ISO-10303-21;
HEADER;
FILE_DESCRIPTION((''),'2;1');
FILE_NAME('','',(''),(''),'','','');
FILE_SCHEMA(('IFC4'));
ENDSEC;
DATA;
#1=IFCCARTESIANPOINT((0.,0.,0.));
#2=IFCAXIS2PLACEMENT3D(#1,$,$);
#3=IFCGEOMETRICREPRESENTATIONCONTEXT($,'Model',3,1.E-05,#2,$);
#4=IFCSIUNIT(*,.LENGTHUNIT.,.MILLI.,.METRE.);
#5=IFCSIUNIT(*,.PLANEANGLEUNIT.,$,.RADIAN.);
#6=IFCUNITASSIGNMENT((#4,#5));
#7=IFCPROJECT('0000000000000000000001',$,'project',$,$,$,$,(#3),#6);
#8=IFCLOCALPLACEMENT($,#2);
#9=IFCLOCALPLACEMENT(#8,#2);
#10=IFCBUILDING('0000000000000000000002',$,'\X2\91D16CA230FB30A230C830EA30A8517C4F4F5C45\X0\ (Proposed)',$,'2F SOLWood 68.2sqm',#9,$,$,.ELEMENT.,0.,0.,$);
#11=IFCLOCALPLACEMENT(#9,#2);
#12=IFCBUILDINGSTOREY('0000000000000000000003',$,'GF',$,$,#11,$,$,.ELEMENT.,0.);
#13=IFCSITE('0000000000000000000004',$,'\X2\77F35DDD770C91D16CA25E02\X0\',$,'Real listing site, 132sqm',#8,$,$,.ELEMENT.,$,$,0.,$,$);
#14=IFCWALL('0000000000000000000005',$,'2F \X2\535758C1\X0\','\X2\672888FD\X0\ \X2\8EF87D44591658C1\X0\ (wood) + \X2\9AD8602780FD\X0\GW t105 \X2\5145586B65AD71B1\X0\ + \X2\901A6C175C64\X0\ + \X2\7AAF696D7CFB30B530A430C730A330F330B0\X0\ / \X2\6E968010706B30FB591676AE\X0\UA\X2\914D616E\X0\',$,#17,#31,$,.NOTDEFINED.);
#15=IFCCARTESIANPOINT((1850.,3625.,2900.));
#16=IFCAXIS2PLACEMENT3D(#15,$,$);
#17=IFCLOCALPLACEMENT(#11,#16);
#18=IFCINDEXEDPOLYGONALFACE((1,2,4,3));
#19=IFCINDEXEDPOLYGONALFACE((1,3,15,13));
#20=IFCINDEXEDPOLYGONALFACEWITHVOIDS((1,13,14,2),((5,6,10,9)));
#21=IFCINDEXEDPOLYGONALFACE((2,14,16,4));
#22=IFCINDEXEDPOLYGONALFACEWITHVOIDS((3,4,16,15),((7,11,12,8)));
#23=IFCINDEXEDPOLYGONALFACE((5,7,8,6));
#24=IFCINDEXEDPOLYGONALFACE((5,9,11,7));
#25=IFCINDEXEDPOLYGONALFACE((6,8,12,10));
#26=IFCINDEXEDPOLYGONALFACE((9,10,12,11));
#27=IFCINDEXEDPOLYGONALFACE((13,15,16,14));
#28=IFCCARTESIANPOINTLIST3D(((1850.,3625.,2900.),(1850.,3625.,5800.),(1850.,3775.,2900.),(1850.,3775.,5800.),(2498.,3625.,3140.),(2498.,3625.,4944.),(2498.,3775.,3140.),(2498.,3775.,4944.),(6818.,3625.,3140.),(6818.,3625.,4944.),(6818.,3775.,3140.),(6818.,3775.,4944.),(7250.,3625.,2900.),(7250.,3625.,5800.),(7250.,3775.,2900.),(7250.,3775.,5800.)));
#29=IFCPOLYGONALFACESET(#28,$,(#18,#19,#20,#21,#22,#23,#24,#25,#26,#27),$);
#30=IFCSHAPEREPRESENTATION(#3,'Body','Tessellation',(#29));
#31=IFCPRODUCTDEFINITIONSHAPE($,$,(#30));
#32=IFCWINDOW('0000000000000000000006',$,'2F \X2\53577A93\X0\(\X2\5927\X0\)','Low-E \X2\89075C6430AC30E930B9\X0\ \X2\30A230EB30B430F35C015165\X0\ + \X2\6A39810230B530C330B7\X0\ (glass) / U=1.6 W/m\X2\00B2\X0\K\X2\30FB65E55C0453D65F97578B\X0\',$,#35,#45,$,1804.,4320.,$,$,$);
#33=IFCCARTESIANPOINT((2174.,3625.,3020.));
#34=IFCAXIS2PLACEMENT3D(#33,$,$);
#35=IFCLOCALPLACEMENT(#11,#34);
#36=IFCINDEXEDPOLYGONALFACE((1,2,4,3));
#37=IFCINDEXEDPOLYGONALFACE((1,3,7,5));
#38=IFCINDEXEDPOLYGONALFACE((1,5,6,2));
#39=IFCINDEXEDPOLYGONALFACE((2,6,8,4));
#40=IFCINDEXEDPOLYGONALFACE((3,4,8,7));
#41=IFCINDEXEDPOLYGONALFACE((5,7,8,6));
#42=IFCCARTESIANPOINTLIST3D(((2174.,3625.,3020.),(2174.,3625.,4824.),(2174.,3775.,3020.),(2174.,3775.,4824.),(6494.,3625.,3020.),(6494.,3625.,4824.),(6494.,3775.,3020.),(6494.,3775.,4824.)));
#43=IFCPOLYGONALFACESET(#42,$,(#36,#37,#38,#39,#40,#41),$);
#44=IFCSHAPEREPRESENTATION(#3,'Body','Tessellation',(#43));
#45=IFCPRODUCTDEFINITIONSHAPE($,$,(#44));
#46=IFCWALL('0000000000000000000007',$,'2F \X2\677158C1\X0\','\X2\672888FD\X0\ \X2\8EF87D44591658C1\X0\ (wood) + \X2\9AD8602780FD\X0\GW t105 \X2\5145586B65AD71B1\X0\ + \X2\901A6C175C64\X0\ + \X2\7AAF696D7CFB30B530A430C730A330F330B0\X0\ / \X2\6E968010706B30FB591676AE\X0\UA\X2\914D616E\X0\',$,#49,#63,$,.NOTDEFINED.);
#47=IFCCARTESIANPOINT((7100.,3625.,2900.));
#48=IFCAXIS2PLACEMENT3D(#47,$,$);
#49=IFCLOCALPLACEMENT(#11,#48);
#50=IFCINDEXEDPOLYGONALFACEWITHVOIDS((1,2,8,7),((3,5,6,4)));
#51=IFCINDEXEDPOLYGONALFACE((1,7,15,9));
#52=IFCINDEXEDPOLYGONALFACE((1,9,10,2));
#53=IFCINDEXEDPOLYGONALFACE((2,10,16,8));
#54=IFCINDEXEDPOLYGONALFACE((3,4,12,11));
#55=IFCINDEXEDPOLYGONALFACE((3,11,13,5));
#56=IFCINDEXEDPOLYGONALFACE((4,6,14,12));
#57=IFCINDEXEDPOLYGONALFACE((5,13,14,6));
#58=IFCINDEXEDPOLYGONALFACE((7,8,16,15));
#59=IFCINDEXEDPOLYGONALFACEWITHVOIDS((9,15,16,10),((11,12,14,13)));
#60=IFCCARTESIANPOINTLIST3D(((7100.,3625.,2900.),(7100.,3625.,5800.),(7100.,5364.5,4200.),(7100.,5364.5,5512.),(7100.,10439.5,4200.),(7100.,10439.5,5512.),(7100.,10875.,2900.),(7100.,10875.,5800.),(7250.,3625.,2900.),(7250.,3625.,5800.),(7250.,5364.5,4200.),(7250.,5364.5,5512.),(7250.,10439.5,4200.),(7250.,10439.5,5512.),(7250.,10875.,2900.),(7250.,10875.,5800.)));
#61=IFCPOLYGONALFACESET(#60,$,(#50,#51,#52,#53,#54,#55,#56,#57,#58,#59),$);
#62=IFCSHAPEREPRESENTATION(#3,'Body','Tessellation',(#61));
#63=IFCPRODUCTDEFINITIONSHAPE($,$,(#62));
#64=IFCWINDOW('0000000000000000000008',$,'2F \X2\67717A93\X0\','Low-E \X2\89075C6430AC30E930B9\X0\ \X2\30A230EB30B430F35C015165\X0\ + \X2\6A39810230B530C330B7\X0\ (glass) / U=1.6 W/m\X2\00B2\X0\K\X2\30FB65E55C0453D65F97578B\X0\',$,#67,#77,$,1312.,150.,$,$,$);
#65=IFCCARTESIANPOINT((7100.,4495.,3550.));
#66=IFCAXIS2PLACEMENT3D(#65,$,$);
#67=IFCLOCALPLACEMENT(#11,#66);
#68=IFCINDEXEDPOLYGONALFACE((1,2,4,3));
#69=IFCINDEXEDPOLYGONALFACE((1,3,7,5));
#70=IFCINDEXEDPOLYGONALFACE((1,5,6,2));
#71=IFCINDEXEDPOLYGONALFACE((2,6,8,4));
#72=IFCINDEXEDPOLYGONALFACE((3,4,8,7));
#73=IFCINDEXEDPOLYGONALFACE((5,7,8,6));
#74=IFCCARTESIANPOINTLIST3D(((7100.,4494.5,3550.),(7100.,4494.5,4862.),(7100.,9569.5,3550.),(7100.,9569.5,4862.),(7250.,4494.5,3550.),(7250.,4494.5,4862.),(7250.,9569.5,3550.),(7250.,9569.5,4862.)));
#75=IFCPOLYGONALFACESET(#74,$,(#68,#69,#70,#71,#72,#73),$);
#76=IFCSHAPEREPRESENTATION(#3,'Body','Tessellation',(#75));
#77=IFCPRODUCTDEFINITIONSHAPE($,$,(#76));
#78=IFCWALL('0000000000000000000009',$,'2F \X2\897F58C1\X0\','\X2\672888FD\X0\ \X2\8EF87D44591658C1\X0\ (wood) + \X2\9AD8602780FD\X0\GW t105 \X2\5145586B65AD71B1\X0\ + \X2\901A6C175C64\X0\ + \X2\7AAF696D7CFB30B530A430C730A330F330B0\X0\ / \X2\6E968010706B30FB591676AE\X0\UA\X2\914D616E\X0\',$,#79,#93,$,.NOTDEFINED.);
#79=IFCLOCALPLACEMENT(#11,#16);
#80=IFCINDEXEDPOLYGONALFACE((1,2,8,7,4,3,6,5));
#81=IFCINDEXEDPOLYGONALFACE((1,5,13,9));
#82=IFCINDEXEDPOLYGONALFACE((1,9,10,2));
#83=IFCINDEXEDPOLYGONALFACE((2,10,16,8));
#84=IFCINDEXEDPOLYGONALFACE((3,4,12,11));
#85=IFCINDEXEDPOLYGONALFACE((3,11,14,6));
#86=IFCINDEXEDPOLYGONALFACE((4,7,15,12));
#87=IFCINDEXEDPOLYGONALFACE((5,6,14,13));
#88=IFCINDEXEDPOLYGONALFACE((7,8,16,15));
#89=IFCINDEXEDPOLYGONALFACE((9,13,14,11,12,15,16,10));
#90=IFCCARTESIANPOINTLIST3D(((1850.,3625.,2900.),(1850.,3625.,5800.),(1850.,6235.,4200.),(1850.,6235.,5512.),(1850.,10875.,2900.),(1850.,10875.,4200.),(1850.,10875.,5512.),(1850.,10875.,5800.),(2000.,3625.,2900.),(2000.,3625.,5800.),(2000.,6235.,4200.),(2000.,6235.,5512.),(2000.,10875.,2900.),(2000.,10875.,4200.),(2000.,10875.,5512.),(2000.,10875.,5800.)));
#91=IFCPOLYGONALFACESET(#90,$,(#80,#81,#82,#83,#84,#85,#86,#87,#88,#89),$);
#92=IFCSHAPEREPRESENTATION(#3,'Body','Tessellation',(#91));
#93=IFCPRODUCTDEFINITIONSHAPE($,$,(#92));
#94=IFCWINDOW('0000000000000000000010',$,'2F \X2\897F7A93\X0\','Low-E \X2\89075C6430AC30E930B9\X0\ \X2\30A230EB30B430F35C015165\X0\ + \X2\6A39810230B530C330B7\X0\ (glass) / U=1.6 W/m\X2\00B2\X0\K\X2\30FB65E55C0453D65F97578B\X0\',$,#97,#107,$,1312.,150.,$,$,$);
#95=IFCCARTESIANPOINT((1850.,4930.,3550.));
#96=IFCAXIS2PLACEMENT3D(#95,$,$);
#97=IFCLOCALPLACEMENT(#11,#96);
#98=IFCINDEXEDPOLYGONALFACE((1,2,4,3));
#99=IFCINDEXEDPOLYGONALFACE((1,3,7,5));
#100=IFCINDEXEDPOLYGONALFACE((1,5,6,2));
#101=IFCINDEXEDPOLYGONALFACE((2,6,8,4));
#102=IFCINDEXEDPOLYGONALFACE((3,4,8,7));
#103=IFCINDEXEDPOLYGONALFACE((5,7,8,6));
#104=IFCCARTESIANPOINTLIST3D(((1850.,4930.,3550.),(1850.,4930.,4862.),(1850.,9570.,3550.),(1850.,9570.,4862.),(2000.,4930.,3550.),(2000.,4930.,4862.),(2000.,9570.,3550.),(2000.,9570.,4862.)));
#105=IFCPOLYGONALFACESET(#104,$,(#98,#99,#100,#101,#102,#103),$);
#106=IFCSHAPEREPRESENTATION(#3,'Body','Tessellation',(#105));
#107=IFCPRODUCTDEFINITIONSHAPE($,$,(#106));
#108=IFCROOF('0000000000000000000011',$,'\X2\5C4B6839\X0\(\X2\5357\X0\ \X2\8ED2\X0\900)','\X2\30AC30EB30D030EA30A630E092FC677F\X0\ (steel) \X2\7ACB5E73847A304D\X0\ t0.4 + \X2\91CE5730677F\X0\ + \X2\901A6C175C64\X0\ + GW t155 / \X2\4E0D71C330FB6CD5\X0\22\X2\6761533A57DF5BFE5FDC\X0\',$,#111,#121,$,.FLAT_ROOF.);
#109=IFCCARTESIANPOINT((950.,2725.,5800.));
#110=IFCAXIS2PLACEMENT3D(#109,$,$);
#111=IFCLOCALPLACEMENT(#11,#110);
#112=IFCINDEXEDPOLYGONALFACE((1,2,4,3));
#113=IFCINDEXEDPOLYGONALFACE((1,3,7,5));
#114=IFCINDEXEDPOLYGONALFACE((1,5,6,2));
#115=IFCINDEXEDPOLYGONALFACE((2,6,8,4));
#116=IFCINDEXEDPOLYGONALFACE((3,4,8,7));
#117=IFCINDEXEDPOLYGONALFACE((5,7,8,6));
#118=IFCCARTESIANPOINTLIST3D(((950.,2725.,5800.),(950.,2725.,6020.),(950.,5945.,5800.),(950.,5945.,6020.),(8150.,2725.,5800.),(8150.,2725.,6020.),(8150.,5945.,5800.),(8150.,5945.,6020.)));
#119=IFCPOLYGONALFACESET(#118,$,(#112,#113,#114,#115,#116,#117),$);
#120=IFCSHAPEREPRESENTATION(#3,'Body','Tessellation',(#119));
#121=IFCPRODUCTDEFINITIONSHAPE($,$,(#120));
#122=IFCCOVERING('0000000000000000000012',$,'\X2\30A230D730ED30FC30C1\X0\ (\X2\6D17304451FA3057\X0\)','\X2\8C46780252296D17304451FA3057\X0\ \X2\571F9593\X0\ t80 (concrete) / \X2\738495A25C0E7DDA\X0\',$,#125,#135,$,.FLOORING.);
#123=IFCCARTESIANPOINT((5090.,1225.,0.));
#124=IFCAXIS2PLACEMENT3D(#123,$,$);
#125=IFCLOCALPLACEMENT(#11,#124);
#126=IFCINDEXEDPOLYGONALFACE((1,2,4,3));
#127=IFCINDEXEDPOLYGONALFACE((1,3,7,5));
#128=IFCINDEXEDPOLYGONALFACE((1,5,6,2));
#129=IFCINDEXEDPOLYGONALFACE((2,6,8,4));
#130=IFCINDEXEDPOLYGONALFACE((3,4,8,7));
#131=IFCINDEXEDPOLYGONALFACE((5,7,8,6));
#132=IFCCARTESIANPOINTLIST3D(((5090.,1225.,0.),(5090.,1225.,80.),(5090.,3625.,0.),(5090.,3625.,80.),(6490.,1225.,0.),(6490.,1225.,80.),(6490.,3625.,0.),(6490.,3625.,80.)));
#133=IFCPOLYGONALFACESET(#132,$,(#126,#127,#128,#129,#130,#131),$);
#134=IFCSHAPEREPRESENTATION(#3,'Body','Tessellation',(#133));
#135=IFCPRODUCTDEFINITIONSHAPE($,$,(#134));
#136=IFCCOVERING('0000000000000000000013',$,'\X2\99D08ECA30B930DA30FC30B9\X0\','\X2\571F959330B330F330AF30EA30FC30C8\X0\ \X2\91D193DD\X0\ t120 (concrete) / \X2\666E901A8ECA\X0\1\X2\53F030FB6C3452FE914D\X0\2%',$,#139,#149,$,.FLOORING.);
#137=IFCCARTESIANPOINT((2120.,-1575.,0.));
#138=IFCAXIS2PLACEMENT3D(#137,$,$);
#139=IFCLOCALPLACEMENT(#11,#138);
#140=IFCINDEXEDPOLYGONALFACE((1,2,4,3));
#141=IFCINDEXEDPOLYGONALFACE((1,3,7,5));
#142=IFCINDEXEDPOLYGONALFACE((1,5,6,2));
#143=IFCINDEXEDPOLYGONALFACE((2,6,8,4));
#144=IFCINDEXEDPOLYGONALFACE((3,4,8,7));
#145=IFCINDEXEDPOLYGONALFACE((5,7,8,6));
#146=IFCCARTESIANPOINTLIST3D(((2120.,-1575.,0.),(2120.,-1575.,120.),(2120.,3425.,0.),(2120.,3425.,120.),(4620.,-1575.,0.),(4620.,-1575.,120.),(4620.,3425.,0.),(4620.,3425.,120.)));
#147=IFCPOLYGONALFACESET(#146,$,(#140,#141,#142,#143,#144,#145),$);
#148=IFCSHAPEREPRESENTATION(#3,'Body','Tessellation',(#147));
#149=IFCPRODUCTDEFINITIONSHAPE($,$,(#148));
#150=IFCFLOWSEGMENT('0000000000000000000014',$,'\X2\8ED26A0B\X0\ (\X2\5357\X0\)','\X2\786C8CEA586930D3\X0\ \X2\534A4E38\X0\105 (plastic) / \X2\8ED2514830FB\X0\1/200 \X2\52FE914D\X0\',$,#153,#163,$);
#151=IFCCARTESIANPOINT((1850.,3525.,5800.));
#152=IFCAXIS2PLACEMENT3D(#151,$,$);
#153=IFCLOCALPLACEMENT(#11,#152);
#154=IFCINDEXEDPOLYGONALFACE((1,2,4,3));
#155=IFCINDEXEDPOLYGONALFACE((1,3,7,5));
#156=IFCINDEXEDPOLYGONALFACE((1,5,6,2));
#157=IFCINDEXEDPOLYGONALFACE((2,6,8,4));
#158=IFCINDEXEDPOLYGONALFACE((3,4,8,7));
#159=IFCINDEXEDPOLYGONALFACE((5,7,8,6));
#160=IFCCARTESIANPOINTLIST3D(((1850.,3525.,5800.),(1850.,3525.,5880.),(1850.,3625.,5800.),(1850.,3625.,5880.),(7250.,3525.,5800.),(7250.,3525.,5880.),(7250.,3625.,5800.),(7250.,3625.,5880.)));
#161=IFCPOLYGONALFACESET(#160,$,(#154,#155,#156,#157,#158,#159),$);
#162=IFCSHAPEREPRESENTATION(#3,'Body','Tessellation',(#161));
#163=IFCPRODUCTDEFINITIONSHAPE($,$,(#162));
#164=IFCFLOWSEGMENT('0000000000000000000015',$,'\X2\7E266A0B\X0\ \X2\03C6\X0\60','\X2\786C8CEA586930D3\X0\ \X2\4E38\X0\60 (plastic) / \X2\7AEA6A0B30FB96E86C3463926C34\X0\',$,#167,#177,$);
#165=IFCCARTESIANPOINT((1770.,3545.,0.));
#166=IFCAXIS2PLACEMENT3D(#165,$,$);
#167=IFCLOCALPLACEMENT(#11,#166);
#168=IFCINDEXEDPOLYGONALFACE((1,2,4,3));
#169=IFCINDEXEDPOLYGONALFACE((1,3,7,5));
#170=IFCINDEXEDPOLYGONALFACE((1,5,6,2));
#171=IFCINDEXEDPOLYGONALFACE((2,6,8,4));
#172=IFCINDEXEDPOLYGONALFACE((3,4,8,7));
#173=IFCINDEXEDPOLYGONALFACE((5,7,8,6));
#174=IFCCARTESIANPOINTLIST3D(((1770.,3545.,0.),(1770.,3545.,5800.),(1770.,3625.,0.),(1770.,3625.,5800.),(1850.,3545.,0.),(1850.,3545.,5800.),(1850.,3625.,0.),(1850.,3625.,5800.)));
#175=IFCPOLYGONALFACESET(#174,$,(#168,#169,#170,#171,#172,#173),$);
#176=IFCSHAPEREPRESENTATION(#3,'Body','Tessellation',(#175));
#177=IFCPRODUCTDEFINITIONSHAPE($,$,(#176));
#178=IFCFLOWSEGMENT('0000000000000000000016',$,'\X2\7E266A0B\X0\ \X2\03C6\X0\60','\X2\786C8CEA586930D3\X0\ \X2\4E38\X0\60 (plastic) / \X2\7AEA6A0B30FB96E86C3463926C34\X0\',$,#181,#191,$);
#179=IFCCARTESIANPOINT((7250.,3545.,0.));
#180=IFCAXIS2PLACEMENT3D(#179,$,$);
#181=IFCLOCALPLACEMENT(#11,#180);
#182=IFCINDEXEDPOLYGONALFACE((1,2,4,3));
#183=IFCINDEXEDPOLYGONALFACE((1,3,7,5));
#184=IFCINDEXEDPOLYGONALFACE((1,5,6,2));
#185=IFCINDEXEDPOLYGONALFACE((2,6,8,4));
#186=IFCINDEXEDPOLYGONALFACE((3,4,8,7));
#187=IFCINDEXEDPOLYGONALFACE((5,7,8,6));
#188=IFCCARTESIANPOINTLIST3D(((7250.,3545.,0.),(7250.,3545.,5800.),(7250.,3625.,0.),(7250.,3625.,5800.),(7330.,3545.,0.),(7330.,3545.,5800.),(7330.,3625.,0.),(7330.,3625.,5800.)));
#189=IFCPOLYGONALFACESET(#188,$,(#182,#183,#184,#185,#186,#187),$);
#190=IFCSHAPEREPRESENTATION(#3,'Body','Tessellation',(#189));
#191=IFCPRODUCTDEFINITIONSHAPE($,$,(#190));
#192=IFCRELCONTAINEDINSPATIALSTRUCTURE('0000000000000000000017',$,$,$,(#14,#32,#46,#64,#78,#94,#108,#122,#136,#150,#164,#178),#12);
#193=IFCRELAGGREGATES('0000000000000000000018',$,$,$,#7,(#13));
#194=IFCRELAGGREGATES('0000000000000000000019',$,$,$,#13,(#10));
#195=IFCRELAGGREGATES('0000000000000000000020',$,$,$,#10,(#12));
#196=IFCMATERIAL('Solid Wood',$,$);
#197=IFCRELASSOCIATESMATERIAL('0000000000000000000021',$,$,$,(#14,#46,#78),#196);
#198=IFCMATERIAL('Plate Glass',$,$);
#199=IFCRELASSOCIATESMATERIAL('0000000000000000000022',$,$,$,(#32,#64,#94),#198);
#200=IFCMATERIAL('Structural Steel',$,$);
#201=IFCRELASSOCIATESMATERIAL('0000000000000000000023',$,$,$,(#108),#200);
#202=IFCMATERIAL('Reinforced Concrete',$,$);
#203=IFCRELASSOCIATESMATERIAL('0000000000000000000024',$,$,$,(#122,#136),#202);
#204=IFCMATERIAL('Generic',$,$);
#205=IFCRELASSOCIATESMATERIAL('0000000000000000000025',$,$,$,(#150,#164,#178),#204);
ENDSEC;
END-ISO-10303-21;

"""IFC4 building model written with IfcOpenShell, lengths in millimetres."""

from ifc_helpers import new_model, si_unit, frame, frame_2d, origin, place, context, project, spatial, rectangle, extrude, material, element, fill, save


model = new_model("IFC4")

# Units and contexts
model_context = context("Model", 3, precision=1e-05, world=origin())
ifc_project = project(units=[si_unit("LENGTHUNIT", "METRE", prefix="MILLI"), si_unit("PLANEANGLEUNIT", "RADIAN")], contexts=[model_context])

# Site, building, storey
site_placement = place(None, origin())
site = spatial("IfcSite", under=ifc_project, at=site_placement, Name="石川県金沢市", ObjectType="Real listing site, 132sqm", CompositionType="ELEMENT", RefElevation=0.0)
building_placement = place(site_placement, origin())
building = spatial("IfcBuilding", under=site, at=building_placement, Name="金沢・アトリエ兼住居 (Proposed)", ObjectType="2F SOLWood 68.2sqm", CompositionType="ELEMENT", ElevationOfRefHeight=0.0, ElevationOfTerrain=0.0)
storey_placement = place(building_placement, origin())
storey = spatial("IfcBuildingStorey", under=building, at=storey_placement, Name="GF", CompositionType="ELEMENT", Elevation=0.0)

# Shared definitions
ifc_material_1 = material(Name="Solid Wood")

# Shared definitions
ifc_material_2 = material(Name="Reinforced Concrete")

# Shared definitions
ifc_material_3 = material(Name="Plate Glass")

# Walls, openings, windows
wall_1_placement = place(storey_placement, frame((1850.0, 3625.0, 2900.0)))
wall_1 = element("IfcWall", 1, at=wall_1_placement, inside=storey, material=ifc_material_1, Name="2F 南壁", Description="木製 軸組外壁 (wood) + 高性能GW t105 充填断熱 + 通気層 + 窯業系サイディング / 準耐火・外皮UA配慮", PredefinedType="NOTDEFINED", context=model_context, shape_type="SweptSolid", body=[
    extrude(rectangle(XDim=5400.0, YDim=150.0, at=frame_2d((2700.0, 75.0))), frame((1850.0, 3625.0, 2900.0)), (0.0, 0.0, 1.0), 2900.0),
])
opening_1_placement = place(storey_placement, frame((2174.0, 3625.0, 3020.0)))
opening_1 = element("IfcOpeningElement", 2, at=opening_1_placement, cuts=wall_1, PredefinedType="NOTDEFINED", context=model_context, shape_type="SweptSolid", body=[
    extrude(rectangle(XDim=4320.0, YDim=150.0, at=frame_2d((2160.0, 75.0))), frame((2174.0, 3625.0, 3020.0)), (0.0, 0.0, 1.0), 1804.0),
])
window_1_placement = place(storey_placement, frame((2174.0, 3625.0, 3020.0)))
window_1 = element("IfcWindow", 3, at=window_1_placement, inside=storey, material=ifc_material_3, Name="2F 南窓(大)", Description="Low-E 複層ガラス アルゴン封入 + 樹脂サッシ (glass) / U=1.6 W/m²K・日射取得型", OverallHeight=1804.0, OverallWidth=4320.0, context=model_context, shape_type="SweptSolid", body=[
    extrude(rectangle(XDim=4320.0, YDim=150.0, at=frame_2d((2160.0, 75.0))), frame((2174.0, 3625.0, 3020.0)), (0.0, 0.0, 1.0), 1804.0),
])
fill(opening_1, window_1)
wall_2_placement = place(storey_placement, frame((7100.0, 3625.0, 2900.0)))
wall_2 = element("IfcWall", 4, at=wall_2_placement, inside=storey, material=ifc_material_1, Name="2F 東壁", Description="木製 軸組外壁 (wood) + 高性能GW t105 充填断熱 + 通気層 + 窯業系サイディング / 準耐火・外皮UA配慮", PredefinedType="NOTDEFINED", context=model_context, shape_type="SweptSolid", body=[
    extrude(rectangle(XDim=150.0, YDim=7250.0, at=frame_2d((75.0, 3625.0))), frame((7100.0, 3625.0, 2900.0)), (0.0, 0.0, 1.0), 2900.0),
])
opening_2_placement = place(storey_placement, frame((7100.0, 4495.0, 3550.0)))
opening_2 = element("IfcOpeningElement", 5, at=opening_2_placement, cuts=wall_2, PredefinedType="NOTDEFINED", context=model_context, shape_type="SweptSolid", body=[
    extrude(rectangle(XDim=150.0, YDim=5075.0, at=frame_2d((75.0, 2537.0))), frame((7100.0, 4495.0, 3550.0)), (0.0, 0.0, 1.0), 1312.0),
])
window_2_placement = place(storey_placement, frame((7100.0, 4495.0, 3550.0)))
window_2 = element("IfcWindow", 6, at=window_2_placement, inside=storey, material=ifc_material_3, Name="2F 東窓", Description="Low-E 複層ガラス アルゴン封入 + 樹脂サッシ (glass) / U=1.6 W/m²K・日射取得型", OverallHeight=1312.0, OverallWidth=150.0, context=model_context, shape_type="SweptSolid", body=[
    extrude(rectangle(XDim=150.0, YDim=5075.0, at=frame_2d((75.0, 2537.0))), frame((7100.0, 4495.0, 3550.0)), (0.0, 0.0, 1.0), 1312.0),
])
fill(opening_2, window_2)
wall_3_placement = place(storey_placement, frame((1850.0, 3625.0, 2900.0)))
wall_3 = element("IfcWall", 7, at=wall_3_placement, inside=storey, material=ifc_material_1, Name="2F 西壁", Description="木製 軸組外壁 (wood) + 高性能GW t105 充填断熱 + 通気層 + 窯業系サイディング / 準耐火・外皮UA配慮", PredefinedType="NOTDEFINED", context=model_context, shape_type="SweptSolid", body=[
    extrude(rectangle(XDim=150.0, YDim=7250.0, at=frame_2d((75.0, 3625.0))), frame((1850.0, 3625.0, 2900.0)), (0.0, 0.0, 1.0), 2900.0),
])
opening_3_placement = place(storey_placement, frame((1850.0, 4930.0, 3550.0)))
opening_3 = element("IfcOpeningElement", 8, at=opening_3_placement, cuts=wall_3, PredefinedType="NOTDEFINED", context=model_context, shape_type="SweptSolid", body=[
    extrude(rectangle(XDim=150.0, YDim=4640.0, at=frame_2d((75.0, 2320.0))), frame((1850.0, 4930.0, 3550.0)), (0.0, 0.0, 1.0), 1312.0),
])
window_3_placement = place(storey_placement, frame((1850.0, 4930.0, 3550.0)))
window_3 = element("IfcWindow", 9, at=window_3_placement, inside=storey, material=ifc_material_3, Name="2F 西窓", Description="Low-E 複層ガラス アルゴン封入 + 樹脂サッシ (glass) / U=1.6 W/m²K・日射取得型", OverallHeight=1312.0, OverallWidth=150.0, context=model_context, shape_type="SweptSolid", body=[
    extrude(rectangle(XDim=150.0, YDim=4640.0, at=frame_2d((75.0, 2320.0))), frame((1850.0, 4930.0, 3550.0)), (0.0, 0.0, 1.0), 1312.0),
])
fill(opening_3, window_3)

# Roof
ifc_material_4 = material(Name="Structural Steel")
for number, where, name in (
    (10, (950.0, 2725.0, 5800.0), "屋根(南 軒900)"),
):
    element("IfcRoof", number, at=place(storey_placement, frame(where)), inside=storey, material=ifc_material_4, Name=name, Description="ガルバリウム鋼板 (steel) 立平葺き t0.4 + 野地板 + 通気層 + GW t155 / 不燃・法22条区域対応", PredefinedType="FLAT_ROOF", context=model_context, shape_type="SweptSolid", body=[
        extrude(rectangle(XDim=7200.0, YDim=3220.0, at=frame_2d((3600.0, 1610.0))), frame((950.0, 2725.0, 5800.0)), (0.0, 0.0, 1.0), 220.0),
    ])

# Coverings
covering_1_placement = place(storey_placement, frame((5090.0, 1225.0, 0.0)))
element("IfcCovering", 11, at=covering_1_placement, inside=storey, material=ifc_material_2, Name="アプローチ (洗い出し)", Description="豆砂利洗い出し 土間 t80 (concrete) / 玄関導線", PredefinedType="FLOORING", context=model_context, shape_type="SweptSolid", body=[
    extrude(rectangle(XDim=1400.0, YDim=2400.0, at=frame_2d((700.0, 1200.0))), frame((5090.0, 1225.0, 0.0)), (0.0, 0.0, 1.0), 80.0),
])
covering_2_placement = place(storey_placement, frame((2120.0, -1575.0, 0.0)))
element("IfcCovering", 12, at=covering_2_placement, inside=storey, material=ifc_material_2, Name="駐車スペース", Description="土間コンクリート 金鏝 t120 (concrete) / 普通車1台・水勾配2%", PredefinedType="FLOORING", context=model_context, shape_type="SweptSolid", body=[
    extrude(rectangle(XDim=2500.0, YDim=5000.0, at=frame_2d((1250.0, 2500.0))), frame((2120.0, -1575.0, 0.0)), (0.0, 0.0, 1.0), 120.0),
])

# Flow segments
ifc_material_5 = material(Name="Generic")
flow_segment_1_placement = place(storey_placement, frame((1850.0, 3525.0, 5800.0)))
element("IfcFlowSegment", 13, at=flow_segment_1_placement, inside=storey, material=ifc_material_5, Name="軒樋 (南)", Description="硬質塩ビ 半丸105 (plastic) / 軒先・1/200 勾配", context=model_context, shape_type="SweptSolid", body=[
    extrude(rectangle(XDim=5400.0, YDim=100.0, at=frame_2d((2700.0, 50.0))), frame((1850.0, 3525.0, 5800.0)), (0.0, 0.0, 1.0), 80.0),
])
flow_segment_2_placement = place(storey_placement, frame((1770.0, 3545.0, 0.0)))
element("IfcFlowSegment", 14, at=flow_segment_2_placement, inside=storey, material=ifc_material_5, Name="縦樋 φ60", Description="硬質塩ビ 丸60 (plastic) / 竪樋・雨水排水", context=model_context, shape_type="SweptSolid", body=[
    extrude(rectangle(XDim=80.0, YDim=80.0, at=frame_2d((40.0, 40.0))), frame((1770.0, 3545.0, 0.0)), (0.0, 0.0, 1.0), 5800.0),
])
flow_segment_3_placement = place(storey_placement, frame((7250.0, 3545.0, 0.0)))
element("IfcFlowSegment", 15, at=flow_segment_3_placement, inside=storey, material=ifc_material_5, Name="縦樋 φ60", Description="硬質塩ビ 丸60 (plastic) / 竪樋・雨水排水", context=model_context, shape_type="SweptSolid", body=[
    extrude(rectangle(XDim=80.0, YDim=80.0, at=frame_2d((40.0, 40.0))), frame((7250.0, 3545.0, 0.0)), (0.0, 0.0, 1.0), 5800.0),
])

save(model, "model.ifc")
